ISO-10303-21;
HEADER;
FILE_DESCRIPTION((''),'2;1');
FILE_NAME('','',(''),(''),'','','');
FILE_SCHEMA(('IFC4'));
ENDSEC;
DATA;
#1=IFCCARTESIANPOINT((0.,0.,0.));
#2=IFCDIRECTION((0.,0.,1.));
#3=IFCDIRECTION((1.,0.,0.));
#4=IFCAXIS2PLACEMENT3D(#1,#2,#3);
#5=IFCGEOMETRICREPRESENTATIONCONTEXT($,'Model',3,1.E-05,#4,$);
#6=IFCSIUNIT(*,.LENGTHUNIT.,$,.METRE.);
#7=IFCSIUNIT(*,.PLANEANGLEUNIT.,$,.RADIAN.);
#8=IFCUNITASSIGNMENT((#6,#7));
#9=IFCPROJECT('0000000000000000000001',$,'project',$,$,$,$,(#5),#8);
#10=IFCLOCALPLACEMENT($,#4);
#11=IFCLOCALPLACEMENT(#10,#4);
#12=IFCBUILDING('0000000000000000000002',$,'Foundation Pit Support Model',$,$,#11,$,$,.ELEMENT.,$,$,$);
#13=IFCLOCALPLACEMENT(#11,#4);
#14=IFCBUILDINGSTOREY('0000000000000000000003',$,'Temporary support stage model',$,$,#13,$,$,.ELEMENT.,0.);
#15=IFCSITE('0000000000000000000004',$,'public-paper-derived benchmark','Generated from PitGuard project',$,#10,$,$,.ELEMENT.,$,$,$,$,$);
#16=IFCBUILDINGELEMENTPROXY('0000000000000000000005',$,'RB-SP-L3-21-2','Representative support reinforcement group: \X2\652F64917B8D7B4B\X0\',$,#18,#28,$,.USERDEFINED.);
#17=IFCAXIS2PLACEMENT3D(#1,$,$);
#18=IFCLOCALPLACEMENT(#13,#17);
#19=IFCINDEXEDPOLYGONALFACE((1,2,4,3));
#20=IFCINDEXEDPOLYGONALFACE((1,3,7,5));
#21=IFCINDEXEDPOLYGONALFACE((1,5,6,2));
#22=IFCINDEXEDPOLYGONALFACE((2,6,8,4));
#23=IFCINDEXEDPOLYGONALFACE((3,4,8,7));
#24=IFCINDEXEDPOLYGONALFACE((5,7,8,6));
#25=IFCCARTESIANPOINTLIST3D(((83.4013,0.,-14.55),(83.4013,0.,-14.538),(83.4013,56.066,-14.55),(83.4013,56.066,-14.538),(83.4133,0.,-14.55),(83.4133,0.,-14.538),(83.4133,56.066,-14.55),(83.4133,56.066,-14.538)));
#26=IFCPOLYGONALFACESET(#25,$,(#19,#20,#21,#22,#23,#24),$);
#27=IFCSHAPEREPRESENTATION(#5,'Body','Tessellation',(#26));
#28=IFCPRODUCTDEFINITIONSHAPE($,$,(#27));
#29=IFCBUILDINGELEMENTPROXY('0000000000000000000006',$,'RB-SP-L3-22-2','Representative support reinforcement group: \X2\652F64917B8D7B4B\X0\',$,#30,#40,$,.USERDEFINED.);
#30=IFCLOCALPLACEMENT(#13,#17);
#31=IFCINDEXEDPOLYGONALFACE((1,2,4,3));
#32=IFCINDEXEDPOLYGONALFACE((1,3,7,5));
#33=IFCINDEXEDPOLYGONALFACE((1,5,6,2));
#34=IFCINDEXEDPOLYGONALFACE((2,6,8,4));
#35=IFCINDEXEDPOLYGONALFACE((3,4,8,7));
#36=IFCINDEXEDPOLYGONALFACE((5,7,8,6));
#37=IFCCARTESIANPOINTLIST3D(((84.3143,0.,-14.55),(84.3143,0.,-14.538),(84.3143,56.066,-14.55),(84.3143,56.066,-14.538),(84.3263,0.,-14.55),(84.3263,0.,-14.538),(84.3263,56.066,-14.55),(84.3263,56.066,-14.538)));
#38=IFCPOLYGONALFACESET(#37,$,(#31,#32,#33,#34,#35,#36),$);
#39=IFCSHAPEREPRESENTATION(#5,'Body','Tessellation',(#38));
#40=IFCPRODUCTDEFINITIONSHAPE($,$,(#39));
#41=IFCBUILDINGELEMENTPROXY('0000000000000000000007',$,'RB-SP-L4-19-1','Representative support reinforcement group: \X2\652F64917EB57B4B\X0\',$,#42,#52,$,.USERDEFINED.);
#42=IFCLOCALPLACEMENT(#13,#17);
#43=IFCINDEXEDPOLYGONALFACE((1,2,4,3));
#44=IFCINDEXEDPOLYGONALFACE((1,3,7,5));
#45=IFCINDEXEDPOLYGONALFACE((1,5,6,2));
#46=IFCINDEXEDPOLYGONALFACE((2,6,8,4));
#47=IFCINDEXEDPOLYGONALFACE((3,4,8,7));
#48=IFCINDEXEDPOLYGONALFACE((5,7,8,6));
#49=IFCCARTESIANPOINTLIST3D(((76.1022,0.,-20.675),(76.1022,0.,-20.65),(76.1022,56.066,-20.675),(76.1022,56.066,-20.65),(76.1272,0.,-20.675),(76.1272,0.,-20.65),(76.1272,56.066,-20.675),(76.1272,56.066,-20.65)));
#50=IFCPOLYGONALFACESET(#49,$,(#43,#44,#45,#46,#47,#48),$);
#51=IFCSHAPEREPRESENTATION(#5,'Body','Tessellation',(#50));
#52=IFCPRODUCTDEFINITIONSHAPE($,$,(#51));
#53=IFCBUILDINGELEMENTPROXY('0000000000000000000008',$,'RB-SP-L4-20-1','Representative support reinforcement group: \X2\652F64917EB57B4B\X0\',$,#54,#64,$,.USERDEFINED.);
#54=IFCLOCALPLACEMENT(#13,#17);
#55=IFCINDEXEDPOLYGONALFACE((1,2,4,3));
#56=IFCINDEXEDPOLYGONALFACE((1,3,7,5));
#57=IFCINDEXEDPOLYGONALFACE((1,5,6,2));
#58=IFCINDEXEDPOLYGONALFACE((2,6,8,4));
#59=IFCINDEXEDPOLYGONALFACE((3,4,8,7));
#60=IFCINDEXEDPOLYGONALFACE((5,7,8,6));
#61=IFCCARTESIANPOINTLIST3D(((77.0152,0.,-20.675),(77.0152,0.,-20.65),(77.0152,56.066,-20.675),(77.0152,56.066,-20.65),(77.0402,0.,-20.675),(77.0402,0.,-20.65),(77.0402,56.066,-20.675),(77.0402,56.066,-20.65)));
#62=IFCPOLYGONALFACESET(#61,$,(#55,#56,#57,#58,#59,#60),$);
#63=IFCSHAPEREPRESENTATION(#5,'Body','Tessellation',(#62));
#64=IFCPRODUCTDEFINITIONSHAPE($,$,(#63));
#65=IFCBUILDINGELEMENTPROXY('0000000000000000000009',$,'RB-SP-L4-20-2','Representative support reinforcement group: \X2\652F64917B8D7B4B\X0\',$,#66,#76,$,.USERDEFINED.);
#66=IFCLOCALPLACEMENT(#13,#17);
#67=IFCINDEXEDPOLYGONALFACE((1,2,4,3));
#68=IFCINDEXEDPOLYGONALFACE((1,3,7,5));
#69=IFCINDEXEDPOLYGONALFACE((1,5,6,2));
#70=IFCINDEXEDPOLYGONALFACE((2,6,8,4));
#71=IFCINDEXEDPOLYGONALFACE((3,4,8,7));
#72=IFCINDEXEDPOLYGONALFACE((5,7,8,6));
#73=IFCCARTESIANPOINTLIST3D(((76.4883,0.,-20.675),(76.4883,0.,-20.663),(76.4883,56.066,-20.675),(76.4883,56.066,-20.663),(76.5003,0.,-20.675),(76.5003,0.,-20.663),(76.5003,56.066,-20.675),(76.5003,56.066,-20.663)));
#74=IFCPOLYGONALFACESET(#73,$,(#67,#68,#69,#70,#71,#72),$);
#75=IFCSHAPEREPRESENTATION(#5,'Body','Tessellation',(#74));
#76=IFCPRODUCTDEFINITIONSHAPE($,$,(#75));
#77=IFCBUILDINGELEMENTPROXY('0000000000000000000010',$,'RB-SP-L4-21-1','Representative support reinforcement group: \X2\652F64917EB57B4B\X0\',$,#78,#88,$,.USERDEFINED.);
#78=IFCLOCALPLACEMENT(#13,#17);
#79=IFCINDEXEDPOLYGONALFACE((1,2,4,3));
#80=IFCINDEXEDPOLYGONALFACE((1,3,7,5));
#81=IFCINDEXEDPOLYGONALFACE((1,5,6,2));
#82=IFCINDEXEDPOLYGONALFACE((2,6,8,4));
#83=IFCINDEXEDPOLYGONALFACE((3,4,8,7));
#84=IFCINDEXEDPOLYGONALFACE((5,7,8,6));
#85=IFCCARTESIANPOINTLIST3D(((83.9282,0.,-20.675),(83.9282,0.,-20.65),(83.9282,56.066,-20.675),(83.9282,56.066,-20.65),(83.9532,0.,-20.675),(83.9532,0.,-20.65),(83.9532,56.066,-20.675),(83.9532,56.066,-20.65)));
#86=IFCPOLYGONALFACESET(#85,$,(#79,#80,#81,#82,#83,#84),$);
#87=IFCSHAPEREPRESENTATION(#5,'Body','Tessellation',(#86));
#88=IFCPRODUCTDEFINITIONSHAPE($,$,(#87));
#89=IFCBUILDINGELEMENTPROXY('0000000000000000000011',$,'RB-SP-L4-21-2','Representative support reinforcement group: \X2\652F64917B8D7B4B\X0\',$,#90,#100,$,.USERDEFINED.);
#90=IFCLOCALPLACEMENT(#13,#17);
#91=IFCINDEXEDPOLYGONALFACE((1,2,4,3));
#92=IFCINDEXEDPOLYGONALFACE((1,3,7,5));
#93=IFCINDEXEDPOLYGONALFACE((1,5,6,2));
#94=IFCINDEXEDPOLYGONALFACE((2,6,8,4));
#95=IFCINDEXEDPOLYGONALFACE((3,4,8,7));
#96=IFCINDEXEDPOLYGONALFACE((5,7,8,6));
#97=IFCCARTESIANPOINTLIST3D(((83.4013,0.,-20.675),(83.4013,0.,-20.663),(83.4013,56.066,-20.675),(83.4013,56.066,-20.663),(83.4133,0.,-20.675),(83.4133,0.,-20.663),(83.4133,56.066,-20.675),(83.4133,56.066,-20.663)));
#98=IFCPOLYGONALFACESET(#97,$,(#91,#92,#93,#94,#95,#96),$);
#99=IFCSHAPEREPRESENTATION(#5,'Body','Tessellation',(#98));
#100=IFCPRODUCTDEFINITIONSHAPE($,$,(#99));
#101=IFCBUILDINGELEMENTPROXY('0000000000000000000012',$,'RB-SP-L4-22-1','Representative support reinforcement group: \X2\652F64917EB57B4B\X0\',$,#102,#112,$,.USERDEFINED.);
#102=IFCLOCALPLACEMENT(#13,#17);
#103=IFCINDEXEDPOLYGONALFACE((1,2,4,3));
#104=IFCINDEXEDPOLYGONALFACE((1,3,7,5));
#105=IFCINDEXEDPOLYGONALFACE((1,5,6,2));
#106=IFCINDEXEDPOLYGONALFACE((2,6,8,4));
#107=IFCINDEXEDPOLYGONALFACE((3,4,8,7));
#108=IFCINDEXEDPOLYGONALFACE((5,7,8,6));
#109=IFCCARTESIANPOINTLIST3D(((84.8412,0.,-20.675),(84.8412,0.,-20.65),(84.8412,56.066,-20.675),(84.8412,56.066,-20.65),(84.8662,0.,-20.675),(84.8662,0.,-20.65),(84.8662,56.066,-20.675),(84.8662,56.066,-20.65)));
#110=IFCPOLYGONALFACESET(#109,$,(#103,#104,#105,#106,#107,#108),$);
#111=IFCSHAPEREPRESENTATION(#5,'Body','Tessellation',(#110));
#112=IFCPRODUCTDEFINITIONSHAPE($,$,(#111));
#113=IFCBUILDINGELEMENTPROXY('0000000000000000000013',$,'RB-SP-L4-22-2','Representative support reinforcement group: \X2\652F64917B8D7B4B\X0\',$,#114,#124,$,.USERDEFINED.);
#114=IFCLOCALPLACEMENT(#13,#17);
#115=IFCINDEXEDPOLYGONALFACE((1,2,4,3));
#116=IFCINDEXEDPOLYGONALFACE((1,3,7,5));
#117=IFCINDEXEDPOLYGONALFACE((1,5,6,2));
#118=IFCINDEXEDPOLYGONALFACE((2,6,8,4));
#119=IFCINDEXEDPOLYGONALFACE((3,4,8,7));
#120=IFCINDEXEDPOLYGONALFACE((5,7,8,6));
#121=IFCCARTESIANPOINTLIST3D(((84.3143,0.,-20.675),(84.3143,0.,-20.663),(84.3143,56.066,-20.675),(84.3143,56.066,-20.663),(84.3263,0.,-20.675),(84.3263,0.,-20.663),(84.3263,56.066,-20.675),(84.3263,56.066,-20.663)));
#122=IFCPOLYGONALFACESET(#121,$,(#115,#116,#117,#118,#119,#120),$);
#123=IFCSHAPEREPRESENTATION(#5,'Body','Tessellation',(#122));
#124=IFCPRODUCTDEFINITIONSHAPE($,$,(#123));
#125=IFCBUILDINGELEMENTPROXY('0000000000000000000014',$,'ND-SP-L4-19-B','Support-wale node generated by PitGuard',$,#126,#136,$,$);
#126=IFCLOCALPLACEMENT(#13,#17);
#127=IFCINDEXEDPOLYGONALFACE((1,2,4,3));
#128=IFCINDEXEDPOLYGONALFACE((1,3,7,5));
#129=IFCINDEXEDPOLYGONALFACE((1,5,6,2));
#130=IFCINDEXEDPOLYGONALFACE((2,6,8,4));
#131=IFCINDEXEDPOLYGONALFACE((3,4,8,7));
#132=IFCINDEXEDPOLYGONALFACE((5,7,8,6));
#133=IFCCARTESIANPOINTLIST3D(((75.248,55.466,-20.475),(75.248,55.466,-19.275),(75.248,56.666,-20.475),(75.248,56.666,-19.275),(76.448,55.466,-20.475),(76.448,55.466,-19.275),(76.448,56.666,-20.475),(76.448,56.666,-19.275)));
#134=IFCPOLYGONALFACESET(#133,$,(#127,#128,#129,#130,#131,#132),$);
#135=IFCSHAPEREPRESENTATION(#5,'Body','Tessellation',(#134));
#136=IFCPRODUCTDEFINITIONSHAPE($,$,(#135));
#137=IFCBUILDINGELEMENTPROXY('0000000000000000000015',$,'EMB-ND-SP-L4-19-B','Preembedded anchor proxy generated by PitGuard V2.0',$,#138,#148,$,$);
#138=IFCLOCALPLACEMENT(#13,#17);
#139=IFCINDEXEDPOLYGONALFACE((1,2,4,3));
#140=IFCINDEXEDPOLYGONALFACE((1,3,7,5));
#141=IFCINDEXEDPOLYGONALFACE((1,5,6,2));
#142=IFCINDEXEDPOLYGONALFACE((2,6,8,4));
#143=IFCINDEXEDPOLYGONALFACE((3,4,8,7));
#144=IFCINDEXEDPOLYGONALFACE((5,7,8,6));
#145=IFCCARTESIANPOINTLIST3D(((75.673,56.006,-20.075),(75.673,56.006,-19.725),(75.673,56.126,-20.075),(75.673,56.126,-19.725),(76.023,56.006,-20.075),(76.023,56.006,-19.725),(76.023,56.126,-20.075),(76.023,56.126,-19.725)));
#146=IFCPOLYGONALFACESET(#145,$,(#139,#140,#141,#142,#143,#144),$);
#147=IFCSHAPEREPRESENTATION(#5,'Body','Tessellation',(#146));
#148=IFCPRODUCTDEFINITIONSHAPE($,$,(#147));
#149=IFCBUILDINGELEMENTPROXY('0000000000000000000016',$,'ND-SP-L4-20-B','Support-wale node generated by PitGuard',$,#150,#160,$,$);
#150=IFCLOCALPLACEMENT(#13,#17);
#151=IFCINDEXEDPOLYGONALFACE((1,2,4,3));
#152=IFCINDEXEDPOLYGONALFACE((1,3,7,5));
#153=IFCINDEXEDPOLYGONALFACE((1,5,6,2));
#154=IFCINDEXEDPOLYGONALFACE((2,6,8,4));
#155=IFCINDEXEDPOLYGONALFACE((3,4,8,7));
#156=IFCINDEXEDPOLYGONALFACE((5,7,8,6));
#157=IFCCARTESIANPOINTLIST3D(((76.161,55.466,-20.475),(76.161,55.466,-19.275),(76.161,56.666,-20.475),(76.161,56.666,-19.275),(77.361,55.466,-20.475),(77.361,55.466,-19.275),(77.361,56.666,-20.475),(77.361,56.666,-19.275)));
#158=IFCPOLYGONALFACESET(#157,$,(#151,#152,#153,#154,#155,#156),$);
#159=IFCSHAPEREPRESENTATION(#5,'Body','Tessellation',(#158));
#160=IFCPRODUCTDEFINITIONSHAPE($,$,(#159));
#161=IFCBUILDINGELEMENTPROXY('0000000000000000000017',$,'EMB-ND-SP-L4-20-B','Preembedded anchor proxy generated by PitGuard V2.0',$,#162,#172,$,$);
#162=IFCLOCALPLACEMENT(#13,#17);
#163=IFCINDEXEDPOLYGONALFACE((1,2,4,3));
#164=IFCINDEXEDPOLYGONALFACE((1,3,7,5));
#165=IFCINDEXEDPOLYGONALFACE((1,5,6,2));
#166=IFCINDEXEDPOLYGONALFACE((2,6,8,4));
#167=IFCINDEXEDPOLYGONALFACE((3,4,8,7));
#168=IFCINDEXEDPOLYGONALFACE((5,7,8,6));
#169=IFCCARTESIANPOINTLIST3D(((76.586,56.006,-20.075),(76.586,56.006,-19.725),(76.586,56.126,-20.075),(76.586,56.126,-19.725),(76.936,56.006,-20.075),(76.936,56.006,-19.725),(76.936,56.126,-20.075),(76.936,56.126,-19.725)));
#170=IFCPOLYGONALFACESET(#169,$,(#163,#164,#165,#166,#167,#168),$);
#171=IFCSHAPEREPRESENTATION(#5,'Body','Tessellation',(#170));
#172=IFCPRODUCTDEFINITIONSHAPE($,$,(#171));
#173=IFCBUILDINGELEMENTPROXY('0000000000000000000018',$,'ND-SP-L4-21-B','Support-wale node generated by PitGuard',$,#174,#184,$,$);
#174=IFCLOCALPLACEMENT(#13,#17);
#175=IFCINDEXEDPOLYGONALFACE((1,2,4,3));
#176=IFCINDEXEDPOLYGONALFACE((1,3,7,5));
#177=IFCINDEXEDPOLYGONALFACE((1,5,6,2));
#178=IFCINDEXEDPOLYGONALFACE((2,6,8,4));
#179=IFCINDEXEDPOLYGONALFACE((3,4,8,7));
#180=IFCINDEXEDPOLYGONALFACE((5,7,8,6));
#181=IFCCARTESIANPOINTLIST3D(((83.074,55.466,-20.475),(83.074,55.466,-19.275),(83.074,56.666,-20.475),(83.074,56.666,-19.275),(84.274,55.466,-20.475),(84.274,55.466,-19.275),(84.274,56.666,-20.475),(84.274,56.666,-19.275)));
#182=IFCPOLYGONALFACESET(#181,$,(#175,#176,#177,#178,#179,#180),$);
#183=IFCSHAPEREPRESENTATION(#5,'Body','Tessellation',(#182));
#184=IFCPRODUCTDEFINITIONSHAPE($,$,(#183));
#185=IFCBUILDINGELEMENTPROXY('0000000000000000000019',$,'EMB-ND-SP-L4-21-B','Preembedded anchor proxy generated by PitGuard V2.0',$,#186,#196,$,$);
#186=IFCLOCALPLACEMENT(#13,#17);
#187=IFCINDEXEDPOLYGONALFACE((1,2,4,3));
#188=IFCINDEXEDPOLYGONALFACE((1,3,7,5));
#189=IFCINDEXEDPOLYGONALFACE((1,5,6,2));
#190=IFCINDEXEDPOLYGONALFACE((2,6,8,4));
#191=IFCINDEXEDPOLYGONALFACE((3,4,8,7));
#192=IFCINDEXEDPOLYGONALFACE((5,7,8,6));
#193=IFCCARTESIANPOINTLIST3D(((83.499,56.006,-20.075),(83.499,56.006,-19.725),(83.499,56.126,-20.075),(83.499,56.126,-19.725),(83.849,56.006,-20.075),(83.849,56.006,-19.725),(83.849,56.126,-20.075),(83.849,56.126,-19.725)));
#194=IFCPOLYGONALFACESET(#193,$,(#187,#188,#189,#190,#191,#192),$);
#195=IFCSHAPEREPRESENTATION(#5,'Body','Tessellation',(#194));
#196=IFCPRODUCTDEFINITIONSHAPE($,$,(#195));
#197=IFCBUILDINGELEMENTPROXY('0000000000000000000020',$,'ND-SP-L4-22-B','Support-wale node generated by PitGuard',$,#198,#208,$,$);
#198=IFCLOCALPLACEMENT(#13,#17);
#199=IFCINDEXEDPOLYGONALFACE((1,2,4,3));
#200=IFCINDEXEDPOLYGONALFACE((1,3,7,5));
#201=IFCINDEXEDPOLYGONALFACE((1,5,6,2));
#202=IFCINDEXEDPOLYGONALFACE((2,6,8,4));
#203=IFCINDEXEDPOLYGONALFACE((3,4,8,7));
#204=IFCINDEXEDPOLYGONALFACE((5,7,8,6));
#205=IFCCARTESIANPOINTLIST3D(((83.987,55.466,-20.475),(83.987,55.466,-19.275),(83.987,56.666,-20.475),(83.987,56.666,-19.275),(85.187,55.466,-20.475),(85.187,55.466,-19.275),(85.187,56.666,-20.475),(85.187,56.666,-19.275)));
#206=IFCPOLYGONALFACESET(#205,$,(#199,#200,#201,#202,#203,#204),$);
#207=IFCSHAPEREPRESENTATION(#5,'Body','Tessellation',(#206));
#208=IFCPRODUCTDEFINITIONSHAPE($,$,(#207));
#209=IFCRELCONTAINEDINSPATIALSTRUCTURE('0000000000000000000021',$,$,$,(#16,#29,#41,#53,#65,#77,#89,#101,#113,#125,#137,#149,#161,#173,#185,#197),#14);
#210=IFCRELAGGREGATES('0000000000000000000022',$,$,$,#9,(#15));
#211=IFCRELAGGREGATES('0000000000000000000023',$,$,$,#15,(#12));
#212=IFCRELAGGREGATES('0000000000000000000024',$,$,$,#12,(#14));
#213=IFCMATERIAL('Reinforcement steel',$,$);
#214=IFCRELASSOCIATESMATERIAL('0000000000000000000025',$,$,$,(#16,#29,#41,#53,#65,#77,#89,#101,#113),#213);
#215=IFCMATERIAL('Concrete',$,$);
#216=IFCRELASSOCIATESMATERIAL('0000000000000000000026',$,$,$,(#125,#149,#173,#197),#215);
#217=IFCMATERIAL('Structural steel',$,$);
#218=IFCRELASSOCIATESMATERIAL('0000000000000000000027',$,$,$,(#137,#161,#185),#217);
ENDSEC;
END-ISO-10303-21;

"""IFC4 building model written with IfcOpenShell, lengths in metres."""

from ifc_helpers import new_model, si_unit, frame, origin_with_axes, origin_2d, place, context, project, spatial, rectangle, extrude, material, element, save


model = new_model("IFC4")

# Units and contexts
model_context = context("Model", 3, precision=1e-05, world=origin_with_axes())
ifc_project = project(units=[si_unit("LENGTHUNIT", "METRE"), si_unit("PLANEANGLEUNIT", "RADIAN")], contexts=[model_context])

# Site, building, storey
site_placement = place(None, origin_with_axes())
site = spatial("IfcSite", under=ifc_project, at=site_placement, Name="public-paper-derived benchmark", Description="Generated from PitGuard project", CompositionType="ELEMENT")
building_placement = place(site_placement, origin_with_axes())
building = spatial("IfcBuilding", under=site, at=building_placement, Name="Foundation Pit Support Model", CompositionType="ELEMENT")
storey_placement = place(building_placement, origin_with_axes())
storey = spatial("IfcBuildingStorey", under=building, at=storey_placement, Name="Temporary support stage model", CompositionType="ELEMENT", Elevation=0.0)

# Shared definitions
ifc_material_1 = material(Name="Concrete")

# Shared definitions
ifc_material_2 = material(Name="Structural steel")

# Building element proxies
ifc_material_3 = material(Name="Reinforcement steel")
for number, where, z_axis, x_axis, name in (
    (1, (83.4073, 28.033, -14.55), (0.0, 0.0, 1.0), (0.0, 1.0, 0.0), "RB-SP-L3-21-2"),
    (2, (84.3203, 28.033, -14.55), (0.0, 0.0, 1.0), (0.0, 1.0, 0.0), "RB-SP-L3-22-2"),
):
    element("IfcBuildingElementProxy", number, at=place(storey_placement, frame(where, z_axis=z_axis, x_axis=x_axis)), inside=storey, material=ifc_material_3, Name=name, Description="Representative support reinforcement group: 支撑箍筋", PredefinedType="USERDEFINED", context=model_context, shape_type="SweptSolid", body=[
        extrude(rectangle(XDim=56.066, YDim=0.012, at=origin_2d()), origin_with_axes(), (0.0, 0.0, 1.0), 0.012),
    ])
for number, where, z_axis, x_axis, name in (
    (3, (76.1147, 28.033, -20.675), (0.0, 0.0, 1.0), (0.0, 1.0, 0.0), "RB-SP-L4-19-1"),
    (4, (77.0277, 28.033, -20.675), (0.0, 0.0, 1.0), (0.0, 1.0, 0.0), "RB-SP-L4-20-1"),
):
    element("IfcBuildingElementProxy", number, at=place(storey_placement, frame(where, z_axis=z_axis, x_axis=x_axis)), inside=storey, material=ifc_material_3, Name=name, Description="Representative support reinforcement group: 支撑纵筋", PredefinedType="USERDEFINED", context=model_context, shape_type="SweptSolid", body=[
        extrude(rectangle(XDim=56.066, YDim=0.025, at=origin_2d()), origin_with_axes(), (0.0, 0.0, 1.0), 0.025),
    ])
proxy_1_placement = place(storey_placement, frame((76.4943, 28.033, -20.675), z_axis=(0.0, 0.0, 1.0), x_axis=(0.0, 1.0, 0.0)))
element("IfcBuildingElementProxy", 5, at=proxy_1_placement, inside=storey, material=ifc_material_3, Name="RB-SP-L4-20-2", Description="Representative support reinforcement group: 支撑箍筋", PredefinedType="USERDEFINED", context=model_context, shape_type="SweptSolid", body=[
    extrude(rectangle(XDim=56.066, YDim=0.012, at=origin_2d()), origin_with_axes(), (0.0, 0.0, 1.0), 0.012),
])
proxy_2_placement = place(storey_placement, frame((83.9407, 28.033, -20.675), z_axis=(0.0, 0.0, 1.0), x_axis=(0.0, 1.0, 0.0)))
element("IfcBuildingElementProxy", 6, at=proxy_2_placement, inside=storey, material=ifc_material_3, Name="RB-SP-L4-21-1", Description="Representative support reinforcement group: 支撑纵筋", PredefinedType="USERDEFINED", context=model_context, shape_type="SweptSolid", body=[
    extrude(rectangle(XDim=56.066, YDim=0.025, at=origin_2d()), origin_with_axes(), (0.0, 0.0, 1.0), 0.025),
])
proxy_3_placement = place(storey_placement, frame((83.4073, 28.033, -20.675), z_axis=(0.0, 0.0, 1.0), x_axis=(0.0, 1.0, 0.0)))
element("IfcBuildingElementProxy", 7, at=proxy_3_placement, inside=storey, material=ifc_material_3, Name="RB-SP-L4-21-2", Description="Representative support reinforcement group: 支撑箍筋", PredefinedType="USERDEFINED", context=model_context, shape_type="SweptSolid", body=[
    extrude(rectangle(XDim=56.066, YDim=0.012, at=origin_2d()), origin_with_axes(), (0.0, 0.0, 1.0), 0.012),
])
proxy_4_placement = place(storey_placement, frame((84.8537, 28.033, -20.675), z_axis=(0.0, 0.0, 1.0), x_axis=(0.0, 1.0, 0.0)))
element("IfcBuildingElementProxy", 8, at=proxy_4_placement, inside=storey, material=ifc_material_3, Name="RB-SP-L4-22-1", Description="Representative support reinforcement group: 支撑纵筋", PredefinedType="USERDEFINED", context=model_context, shape_type="SweptSolid", body=[
    extrude(rectangle(XDim=56.066, YDim=0.025, at=origin_2d()), origin_with_axes(), (0.0, 0.0, 1.0), 0.025),
])
proxy_5_placement = place(storey_placement, frame((84.3203, 28.033, -20.675), z_axis=(0.0, 0.0, 1.0), x_axis=(0.0, 1.0, 0.0)))
element("IfcBuildingElementProxy", 9, at=proxy_5_placement, inside=storey, material=ifc_material_3, Name="RB-SP-L4-22-2", Description="Representative support reinforcement group: 支撑箍筋", PredefinedType="USERDEFINED", context=model_context, shape_type="SweptSolid", body=[
    extrude(rectangle(XDim=56.066, YDim=0.012, at=origin_2d()), origin_with_axes(), (0.0, 0.0, 1.0), 0.012),
])
proxy_6_placement = place(storey_placement, frame((75.848, 56.066, -20.475), z_axis=(0.0, 0.0, 1.0), x_axis=(1.0, 0.0, 0.0)))
element("IfcBuildingElementProxy", 10, at=proxy_6_placement, inside=storey, material=ifc_material_1, Name="ND-SP-L4-19-B", Description="Support-wale node generated by PitGuard", context=model_context, shape_type="SweptSolid", body=[
    extrude(rectangle(XDim=1.2, YDim=1.2, at=origin_2d()), origin_with_axes(), (0.0, 0.0, 1.0), 1.2),
])
proxy_7_placement = place(storey_placement, frame((75.848, 56.066, -20.075), z_axis=(0.0, 0.0, 1.0), x_axis=(1.0, 0.0, 0.0)))
element("IfcBuildingElementProxy", 11, at=proxy_7_placement, inside=storey, material=ifc_material_2, Name="EMB-ND-SP-L4-19-B", Description="Preembedded anchor proxy generated by PitGuard V2.0", context=model_context, shape_type="SweptSolid", body=[
    extrude(rectangle(XDim=0.35, YDim=0.12, at=origin_2d()), origin_with_axes(), (0.0, 0.0, 1.0), 0.35),
])
proxy_8_placement = place(storey_placement, frame((76.761, 56.066, -20.475), z_axis=(0.0, 0.0, 1.0), x_axis=(1.0, 0.0, 0.0)))
element("IfcBuildingElementProxy", 12, at=proxy_8_placement, inside=storey, material=ifc_material_1, Name="ND-SP-L4-20-B", Description="Support-wale node generated by PitGuard", context=model_context, shape_type="SweptSolid", body=[
    extrude(rectangle(XDim=1.2, YDim=1.2, at=origin_2d()), origin_with_axes(), (0.0, 0.0, 1.0), 1.2),
])
proxy_9_placement = place(storey_placement, frame((76.761, 56.066, -20.075), z_axis=(0.0, 0.0, 1.0), x_axis=(1.0, 0.0, 0.0)))
element("IfcBuildingElementProxy", 13, at=proxy_9_placement, inside=storey, material=ifc_material_2, Name="EMB-ND-SP-L4-20-B", Description="Preembedded anchor proxy generated by PitGuard V2.0", context=model_context, shape_type="SweptSolid", body=[
    extrude(rectangle(XDim=0.35, YDim=0.12, at=origin_2d()), origin_with_axes(), (0.0, 0.0, 1.0), 0.35),
])
proxy_10_placement = place(storey_placement, frame((83.674, 56.066, -20.475), z_axis=(0.0, 0.0, 1.0), x_axis=(1.0, 0.0, 0.0)))
element("IfcBuildingElementProxy", 14, at=proxy_10_placement, inside=storey, material=ifc_material_1, Name="ND-SP-L4-21-B", Description="Support-wale node generated by PitGuard", context=model_context, shape_type="SweptSolid", body=[
    extrude(rectangle(XDim=1.2, YDim=1.2, at=origin_2d()), origin_with_axes(), (0.0, 0.0, 1.0), 1.2),
])
proxy_11_placement = place(storey_placement, frame((83.674, 56.066, -20.075), z_axis=(0.0, 0.0, 1.0), x_axis=(1.0, 0.0, 0.0)))
element("IfcBuildingElementProxy", 15, at=proxy_11_placement, inside=storey, material=ifc_material_2, Name="EMB-ND-SP-L4-21-B", Description="Preembedded anchor proxy generated by PitGuard V2.0", context=model_context, shape_type="SweptSolid", body=[
    extrude(rectangle(XDim=0.35, YDim=0.12, at=origin_2d()), origin_with_axes(), (0.0, 0.0, 1.0), 0.35),
])
proxy_12_placement = place(storey_placement, frame((84.587, 56.066, -20.475), z_axis=(0.0, 0.0, 1.0), x_axis=(1.0, 0.0, 0.0)))
element("IfcBuildingElementProxy", 16, at=proxy_12_placement, inside=storey, material=ifc_material_1, Name="ND-SP-L4-22-B", Description="Support-wale node generated by PitGuard", context=model_context, shape_type="SweptSolid", body=[
    extrude(rectangle(XDim=1.2, YDim=1.2, at=origin_2d()), origin_with_axes(), (0.0, 0.0, 1.0), 1.2),
])

save(model, "model.ifc")
